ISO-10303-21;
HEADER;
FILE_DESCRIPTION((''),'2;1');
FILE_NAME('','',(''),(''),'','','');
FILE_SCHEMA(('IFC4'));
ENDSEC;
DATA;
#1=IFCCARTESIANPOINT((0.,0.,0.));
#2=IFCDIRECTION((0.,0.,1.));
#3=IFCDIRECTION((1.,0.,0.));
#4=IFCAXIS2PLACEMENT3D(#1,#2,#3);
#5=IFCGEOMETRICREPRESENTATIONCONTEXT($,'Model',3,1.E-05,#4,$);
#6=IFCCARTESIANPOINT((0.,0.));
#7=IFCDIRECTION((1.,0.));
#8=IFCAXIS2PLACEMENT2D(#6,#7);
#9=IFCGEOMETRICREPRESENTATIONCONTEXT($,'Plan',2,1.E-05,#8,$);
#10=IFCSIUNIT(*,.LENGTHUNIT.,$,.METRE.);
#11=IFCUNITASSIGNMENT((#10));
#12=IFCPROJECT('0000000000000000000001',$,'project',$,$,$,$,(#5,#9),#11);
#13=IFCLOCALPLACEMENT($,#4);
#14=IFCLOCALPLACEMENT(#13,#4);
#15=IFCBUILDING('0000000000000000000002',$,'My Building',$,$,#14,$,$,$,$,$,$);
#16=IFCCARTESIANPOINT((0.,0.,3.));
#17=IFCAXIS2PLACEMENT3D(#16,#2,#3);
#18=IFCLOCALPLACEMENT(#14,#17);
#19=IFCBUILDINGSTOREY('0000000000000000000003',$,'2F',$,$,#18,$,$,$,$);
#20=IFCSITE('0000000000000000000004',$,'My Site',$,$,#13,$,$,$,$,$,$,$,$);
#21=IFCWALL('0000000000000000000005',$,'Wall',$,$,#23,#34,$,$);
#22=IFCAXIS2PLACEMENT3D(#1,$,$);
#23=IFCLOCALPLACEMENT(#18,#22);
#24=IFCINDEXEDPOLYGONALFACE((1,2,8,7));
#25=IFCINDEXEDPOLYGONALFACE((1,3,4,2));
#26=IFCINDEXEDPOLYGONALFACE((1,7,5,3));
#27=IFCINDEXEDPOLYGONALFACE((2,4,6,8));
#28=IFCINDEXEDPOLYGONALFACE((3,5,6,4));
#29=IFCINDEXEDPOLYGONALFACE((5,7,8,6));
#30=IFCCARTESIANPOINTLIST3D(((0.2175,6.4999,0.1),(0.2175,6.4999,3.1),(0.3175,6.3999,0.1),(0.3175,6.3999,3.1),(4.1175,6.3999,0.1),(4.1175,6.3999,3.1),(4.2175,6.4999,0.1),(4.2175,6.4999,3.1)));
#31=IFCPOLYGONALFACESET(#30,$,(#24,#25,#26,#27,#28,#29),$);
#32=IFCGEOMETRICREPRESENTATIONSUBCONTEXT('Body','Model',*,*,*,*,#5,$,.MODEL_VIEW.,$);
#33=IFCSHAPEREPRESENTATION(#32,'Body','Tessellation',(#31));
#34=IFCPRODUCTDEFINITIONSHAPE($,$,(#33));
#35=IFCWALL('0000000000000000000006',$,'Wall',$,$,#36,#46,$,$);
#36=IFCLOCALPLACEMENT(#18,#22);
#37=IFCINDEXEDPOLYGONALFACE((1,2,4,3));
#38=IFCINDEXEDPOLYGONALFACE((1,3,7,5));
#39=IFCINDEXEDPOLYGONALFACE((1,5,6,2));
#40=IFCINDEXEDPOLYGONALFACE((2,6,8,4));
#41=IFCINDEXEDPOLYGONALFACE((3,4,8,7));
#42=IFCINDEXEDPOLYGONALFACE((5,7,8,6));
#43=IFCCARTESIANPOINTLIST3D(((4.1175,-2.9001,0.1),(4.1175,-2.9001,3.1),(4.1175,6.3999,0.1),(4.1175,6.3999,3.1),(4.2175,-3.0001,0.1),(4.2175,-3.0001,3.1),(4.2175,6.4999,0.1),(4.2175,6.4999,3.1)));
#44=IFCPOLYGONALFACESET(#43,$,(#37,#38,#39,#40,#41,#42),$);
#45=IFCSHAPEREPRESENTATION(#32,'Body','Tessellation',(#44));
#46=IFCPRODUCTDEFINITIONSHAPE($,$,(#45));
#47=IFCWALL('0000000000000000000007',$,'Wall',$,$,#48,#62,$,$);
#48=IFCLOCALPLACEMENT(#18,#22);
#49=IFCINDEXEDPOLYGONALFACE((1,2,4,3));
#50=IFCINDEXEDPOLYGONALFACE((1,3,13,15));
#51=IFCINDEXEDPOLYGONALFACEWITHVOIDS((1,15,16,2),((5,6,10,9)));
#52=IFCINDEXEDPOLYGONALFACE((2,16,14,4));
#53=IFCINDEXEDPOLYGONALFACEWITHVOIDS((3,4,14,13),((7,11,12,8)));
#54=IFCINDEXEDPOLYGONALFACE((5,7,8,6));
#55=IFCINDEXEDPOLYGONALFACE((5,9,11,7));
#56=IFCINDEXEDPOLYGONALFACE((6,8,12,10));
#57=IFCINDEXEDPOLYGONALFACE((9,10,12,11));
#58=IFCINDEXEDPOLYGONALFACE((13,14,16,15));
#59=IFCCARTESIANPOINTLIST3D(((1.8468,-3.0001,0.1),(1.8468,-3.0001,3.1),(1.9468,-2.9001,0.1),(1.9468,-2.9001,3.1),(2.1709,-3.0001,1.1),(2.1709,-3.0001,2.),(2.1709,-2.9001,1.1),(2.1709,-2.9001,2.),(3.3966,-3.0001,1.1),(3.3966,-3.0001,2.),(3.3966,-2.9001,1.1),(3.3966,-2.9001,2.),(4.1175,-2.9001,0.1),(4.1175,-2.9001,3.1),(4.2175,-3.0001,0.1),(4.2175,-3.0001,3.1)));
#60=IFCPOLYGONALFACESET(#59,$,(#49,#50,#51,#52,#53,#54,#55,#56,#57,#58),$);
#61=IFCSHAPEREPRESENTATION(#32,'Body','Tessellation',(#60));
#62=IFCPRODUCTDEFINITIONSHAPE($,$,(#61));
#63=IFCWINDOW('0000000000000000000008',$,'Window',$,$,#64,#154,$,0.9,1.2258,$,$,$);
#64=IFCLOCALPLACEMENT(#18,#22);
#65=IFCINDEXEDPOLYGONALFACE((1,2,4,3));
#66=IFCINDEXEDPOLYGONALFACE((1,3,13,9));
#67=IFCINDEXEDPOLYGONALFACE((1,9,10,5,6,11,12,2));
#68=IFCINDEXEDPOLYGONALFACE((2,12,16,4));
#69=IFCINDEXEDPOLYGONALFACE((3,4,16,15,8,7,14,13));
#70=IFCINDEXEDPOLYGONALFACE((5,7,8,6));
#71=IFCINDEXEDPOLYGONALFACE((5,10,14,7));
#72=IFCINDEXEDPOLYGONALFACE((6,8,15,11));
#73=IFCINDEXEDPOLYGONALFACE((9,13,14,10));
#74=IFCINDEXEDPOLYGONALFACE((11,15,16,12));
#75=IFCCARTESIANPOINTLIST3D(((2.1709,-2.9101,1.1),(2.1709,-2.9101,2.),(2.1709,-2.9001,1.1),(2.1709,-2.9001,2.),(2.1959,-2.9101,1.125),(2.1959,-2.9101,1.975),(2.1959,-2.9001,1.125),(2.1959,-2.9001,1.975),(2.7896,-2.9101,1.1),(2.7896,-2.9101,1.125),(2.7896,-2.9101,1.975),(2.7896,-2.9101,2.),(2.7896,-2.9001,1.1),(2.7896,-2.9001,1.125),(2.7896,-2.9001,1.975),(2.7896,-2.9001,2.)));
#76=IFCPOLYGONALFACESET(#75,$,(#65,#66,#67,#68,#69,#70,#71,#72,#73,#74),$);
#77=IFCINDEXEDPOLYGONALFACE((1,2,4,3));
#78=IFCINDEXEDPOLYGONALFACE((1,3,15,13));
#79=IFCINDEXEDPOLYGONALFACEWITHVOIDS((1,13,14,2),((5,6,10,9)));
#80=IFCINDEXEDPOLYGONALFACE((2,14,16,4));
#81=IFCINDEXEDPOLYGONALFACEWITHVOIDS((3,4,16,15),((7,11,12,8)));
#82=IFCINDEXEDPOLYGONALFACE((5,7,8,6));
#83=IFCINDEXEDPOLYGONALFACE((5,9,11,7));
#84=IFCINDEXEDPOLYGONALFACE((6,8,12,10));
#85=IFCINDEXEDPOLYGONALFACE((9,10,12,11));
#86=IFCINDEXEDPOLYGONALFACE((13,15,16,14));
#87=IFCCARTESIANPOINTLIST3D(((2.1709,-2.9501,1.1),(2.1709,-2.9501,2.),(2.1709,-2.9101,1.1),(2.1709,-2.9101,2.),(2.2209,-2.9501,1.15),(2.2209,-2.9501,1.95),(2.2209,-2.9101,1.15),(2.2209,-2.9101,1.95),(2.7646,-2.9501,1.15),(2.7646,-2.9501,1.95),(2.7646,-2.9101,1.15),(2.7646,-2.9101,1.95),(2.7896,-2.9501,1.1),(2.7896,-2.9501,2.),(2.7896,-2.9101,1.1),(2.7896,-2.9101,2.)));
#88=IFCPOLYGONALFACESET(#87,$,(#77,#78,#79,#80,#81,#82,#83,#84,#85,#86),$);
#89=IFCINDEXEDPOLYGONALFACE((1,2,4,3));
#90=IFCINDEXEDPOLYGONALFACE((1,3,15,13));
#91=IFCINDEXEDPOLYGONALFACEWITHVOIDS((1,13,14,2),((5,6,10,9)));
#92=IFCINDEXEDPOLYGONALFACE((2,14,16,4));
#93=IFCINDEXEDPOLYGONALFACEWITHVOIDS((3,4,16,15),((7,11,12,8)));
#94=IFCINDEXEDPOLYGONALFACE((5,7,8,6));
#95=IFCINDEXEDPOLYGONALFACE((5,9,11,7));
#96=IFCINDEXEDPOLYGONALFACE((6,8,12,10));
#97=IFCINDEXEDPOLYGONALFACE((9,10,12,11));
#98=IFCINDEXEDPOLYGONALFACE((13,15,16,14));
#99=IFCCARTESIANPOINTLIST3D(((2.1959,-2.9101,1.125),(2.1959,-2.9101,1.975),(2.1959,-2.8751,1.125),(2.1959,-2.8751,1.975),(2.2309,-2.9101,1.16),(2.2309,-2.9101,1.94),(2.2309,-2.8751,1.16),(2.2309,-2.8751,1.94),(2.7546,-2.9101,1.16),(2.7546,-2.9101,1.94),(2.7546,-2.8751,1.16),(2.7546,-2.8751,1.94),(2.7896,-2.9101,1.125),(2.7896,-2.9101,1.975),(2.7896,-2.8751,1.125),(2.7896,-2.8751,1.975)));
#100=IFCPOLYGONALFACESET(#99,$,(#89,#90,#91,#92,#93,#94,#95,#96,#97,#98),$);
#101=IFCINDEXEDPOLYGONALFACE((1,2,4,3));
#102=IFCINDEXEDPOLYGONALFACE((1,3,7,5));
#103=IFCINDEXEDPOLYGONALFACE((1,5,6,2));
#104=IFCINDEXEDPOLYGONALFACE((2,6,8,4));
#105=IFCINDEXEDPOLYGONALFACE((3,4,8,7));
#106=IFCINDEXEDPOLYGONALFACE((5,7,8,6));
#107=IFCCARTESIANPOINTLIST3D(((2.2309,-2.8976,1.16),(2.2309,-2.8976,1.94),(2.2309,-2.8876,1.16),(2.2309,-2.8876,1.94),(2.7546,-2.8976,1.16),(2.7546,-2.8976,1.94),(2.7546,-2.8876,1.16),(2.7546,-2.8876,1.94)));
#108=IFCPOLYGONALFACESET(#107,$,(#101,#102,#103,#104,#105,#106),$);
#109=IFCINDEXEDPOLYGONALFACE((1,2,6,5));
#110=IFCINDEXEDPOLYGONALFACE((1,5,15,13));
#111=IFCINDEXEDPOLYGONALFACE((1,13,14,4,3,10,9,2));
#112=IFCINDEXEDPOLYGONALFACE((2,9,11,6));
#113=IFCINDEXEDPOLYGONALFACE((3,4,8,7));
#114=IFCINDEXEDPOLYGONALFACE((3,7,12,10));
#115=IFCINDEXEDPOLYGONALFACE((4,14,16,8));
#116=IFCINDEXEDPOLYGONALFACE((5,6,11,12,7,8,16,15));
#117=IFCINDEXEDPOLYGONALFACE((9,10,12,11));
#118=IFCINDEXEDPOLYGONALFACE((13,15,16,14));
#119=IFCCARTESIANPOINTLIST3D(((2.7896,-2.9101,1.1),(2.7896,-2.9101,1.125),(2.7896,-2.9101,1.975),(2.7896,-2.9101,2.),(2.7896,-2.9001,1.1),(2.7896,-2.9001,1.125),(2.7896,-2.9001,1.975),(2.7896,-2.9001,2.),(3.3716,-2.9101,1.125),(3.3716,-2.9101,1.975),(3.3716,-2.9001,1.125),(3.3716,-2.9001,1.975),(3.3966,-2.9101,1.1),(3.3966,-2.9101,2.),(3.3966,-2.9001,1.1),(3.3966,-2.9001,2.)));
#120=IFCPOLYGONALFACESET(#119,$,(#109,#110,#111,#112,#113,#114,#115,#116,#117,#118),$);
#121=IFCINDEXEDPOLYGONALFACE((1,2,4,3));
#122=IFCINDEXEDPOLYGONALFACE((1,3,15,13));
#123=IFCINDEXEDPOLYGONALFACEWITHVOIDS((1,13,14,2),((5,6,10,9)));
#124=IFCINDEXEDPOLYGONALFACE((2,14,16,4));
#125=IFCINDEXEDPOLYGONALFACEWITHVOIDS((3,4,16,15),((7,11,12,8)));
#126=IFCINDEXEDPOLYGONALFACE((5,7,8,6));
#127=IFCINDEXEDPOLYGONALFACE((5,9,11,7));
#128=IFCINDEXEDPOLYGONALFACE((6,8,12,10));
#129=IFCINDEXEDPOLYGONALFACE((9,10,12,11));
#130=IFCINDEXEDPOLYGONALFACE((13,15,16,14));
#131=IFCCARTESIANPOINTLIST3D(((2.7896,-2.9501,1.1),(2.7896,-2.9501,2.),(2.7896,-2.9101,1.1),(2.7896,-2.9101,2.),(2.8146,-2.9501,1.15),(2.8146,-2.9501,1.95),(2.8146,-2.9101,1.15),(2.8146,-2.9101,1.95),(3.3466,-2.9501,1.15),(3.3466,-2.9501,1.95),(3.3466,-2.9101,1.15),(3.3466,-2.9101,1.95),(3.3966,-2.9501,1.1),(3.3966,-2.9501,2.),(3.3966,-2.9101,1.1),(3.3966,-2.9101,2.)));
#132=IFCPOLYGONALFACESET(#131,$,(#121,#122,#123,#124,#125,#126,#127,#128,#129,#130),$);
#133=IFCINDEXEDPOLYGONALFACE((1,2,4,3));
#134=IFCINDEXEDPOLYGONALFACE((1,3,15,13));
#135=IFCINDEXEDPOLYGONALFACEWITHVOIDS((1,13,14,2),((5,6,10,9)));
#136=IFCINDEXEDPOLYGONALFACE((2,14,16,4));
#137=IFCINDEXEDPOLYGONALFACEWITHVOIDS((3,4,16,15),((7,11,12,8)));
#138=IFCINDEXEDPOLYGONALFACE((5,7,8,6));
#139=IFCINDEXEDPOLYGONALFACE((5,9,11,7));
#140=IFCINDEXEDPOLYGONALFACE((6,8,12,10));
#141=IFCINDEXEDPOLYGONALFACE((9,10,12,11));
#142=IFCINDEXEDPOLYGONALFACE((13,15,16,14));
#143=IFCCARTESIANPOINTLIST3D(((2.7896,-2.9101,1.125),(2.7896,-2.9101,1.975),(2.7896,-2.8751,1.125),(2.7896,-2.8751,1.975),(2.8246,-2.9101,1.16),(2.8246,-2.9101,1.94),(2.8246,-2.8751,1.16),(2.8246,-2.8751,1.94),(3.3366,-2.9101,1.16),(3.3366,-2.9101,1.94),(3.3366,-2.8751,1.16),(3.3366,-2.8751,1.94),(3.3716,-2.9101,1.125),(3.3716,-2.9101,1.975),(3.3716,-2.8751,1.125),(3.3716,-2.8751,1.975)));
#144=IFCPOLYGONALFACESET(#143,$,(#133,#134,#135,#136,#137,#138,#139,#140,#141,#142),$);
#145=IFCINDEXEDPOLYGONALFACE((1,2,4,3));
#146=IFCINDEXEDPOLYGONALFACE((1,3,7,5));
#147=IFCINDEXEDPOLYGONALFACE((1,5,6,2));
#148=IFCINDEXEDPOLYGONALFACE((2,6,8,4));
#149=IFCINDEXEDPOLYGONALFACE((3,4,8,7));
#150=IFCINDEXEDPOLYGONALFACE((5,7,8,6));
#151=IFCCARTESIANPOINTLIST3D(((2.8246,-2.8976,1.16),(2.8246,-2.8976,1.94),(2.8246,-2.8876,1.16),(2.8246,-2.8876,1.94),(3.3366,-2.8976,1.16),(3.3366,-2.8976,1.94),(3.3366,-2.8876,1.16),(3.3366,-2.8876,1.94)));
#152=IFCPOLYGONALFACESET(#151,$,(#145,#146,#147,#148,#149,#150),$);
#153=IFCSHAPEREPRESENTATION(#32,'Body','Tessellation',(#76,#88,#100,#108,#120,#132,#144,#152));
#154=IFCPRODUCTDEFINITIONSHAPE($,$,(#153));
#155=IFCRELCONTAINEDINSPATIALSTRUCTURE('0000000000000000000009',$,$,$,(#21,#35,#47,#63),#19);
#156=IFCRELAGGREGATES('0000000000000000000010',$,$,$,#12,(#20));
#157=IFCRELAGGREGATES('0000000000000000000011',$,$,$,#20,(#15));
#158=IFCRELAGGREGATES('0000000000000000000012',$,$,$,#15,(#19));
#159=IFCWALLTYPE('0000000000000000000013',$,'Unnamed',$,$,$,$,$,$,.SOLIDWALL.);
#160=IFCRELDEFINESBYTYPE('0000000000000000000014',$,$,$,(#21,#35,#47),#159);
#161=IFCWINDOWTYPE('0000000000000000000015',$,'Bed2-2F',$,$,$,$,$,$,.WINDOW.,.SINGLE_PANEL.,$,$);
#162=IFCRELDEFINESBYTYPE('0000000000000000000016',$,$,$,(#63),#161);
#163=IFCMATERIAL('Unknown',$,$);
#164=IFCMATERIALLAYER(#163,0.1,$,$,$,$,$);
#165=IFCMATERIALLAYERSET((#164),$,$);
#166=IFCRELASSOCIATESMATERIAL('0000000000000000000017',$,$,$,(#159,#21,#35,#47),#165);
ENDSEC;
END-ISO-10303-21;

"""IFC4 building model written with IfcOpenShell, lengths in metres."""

from ifc_helpers import new_model, entity, si_unit, frame, origin_with_axes, origin_2d_with_axis, place, context, subcontext, project, spatial, line, indexed_curve, outline, extrude, shape, source, transform, mapped, material, layer, layer_set, layer_usage, type_object, type_shapes, element, fill, save


model = new_model("IFC4")

# Units and contexts
model_context = context("Model", 3, precision=1e-05, world=origin_with_axes())
plan_context = context("Plan", 2, precision=1e-05, world=origin_2d_with_axis())
body_context_1 = subcontext(model_context, "Body", "Model", "MODEL_VIEW")
body_context_2 = subcontext(plan_context, "Body", "Plan", "PLAN_VIEW")
ifc_project = project(units=[si_unit("LENGTHUNIT", "METRE")], contexts=[model_context, plan_context])

# Site, building, storey
site_placement = place(None, origin_with_axes())
site = spatial("IfcSite", under=ifc_project, at=site_placement, Name="My Site")
building_placement = place(site_placement, origin_with_axes())
building = spatial("IfcBuilding", under=site, at=building_placement, Name="My Building")
storey_placement = place(building_placement, frame((0.0, 0.0, 3.0), z_axis=(0.0, 0.0, 1.0), x_axis=(1.0, 0.0, 0.0)))
storey = spatial("IfcBuildingStorey", under=building, at=storey_placement, Name="2F")

# Walls
ifc_material = material(Name="Unknown")
ifc_layer = layer(ifc_material, 0.1)
ifc_layer_set = layer_set([ifc_layer])
ifc_layer_usage_1 = layer_usage(ifc_layer_set, "AXIS2", "POSITIVE", 0.0)
wall_type = type_object("IfcWallType", Name="Unnamed", PredefinedType="SOLIDWALL", material=ifc_layer_set)
wall_1_placement = place(storey_placement, frame((0.3175, 6.3999, 0.1), z_axis=(0.0, 0.0, 1.0), x_axis=(1.0, 0.0, 0.0)))
element("IfcWall", 1, at=wall_1_placement, inside=storey, type_object=wall_type, material=ifc_layer_usage_1, Name="Wall", context=body_context_1, shape_type="SweptSolid", body=[
    extrude(outline(indexed_curve([(0.0, 0.0), (-0.1, 0.1), (3.9, 0.1), (3.8, 0.0)], segments=[line(1, 2, 3, 4, 1)])), origin_with_axes(), (0.0, 0.0, 1.0), 3.0),
])
ifc_layer_usage_2 = layer_usage(ifc_layer_set, "AXIS2", "POSITIVE", 0.0)
wall_2_placement = place(storey_placement, frame((4.1175, 6.3999, 0.1), z_axis=(0.0, 0.0, 1.0), x_axis=(0.0, -1.0, 0.0)))
element("IfcWall", 2, at=wall_2_placement, inside=storey, type_object=wall_type, material=ifc_layer_usage_2, Name="Wall", context=body_context_1, shape_type="SweptSolid", body=[
    extrude(outline(indexed_curve([(0.0, 0.0), (-0.1, 0.1), (9.4, 0.1), (9.3, 0.0)], segments=[line(1, 2, 3, 4, 1)])), origin_with_axes(), (0.0, 0.0, 1.0), 3.0),
])

# Wall, opening, window
ifc_layer_usage_3 = layer_usage(ifc_layer_set, "AXIS2", "POSITIVE", 0.0)
wall_3_placement = place(storey_placement, frame((4.1175, -2.9001, 0.1), z_axis=(0.0, 0.0, 1.0), x_axis=(-1.0, 0.0, 0.0)))
wall_3 = element("IfcWall", 3, at=wall_3_placement, inside=storey, type_object=wall_type, material=ifc_layer_usage_3, Name="Wall", context=body_context_1, shape_type="SweptSolid", body=[
    extrude(outline(indexed_curve([(0.0, 0.0), (-0.1, 0.1), (2.2706, 0.1), (2.1706, 0.0)], segments=[line(1, 2, 3, 4, 1)])), origin_with_axes(), (0.0, 0.0, 1.0), 3.0),
])
shared_shape_1 = source(origin_with_axes(), body_context_1, "Body", "SweptSolid", [
    extrude(outline(indexed_curve([(0.0, 0.0), (1.2258, 0.0), (1.2258, 0.9), (0.0, 0.9)], segments=[line(1, 2, 3, 4, 1)])), frame((0.0, -0.6, 0.0), z_axis=(0.0, -1.0, 0.0), x_axis=(1.0, 0.0, 0.0)), (0.0, 0.0, -1.0), 1.2),
])
opening_1_placement = place(wall_3_placement, frame((1.9466, 0.1, 1.0), z_axis=(0.0, 0.0, 1.0), x_axis=(-1.0, 0.0, 0.0)))
opening_1 = element("IfcOpeningElement", 4, at=opening_1_placement, cuts=wall_3, PredefinedType="OPENING", context=body_context_1, shape_type="MappedRepresentation", body=[
    mapped(shared_shape_1, transform((0.0, 0.0, 0.0), x_axis=(1.0, 0.0, 0.0), y_axis=(0.0, 1.0, 0.0), z_axis=(0.0, 0.0, 1.0), scale=1.0)),
])
window_type_1 = type_object("IfcWindowType", Name="Bed2-2F", PartitioningType="SINGLE_PANEL", PredefinedType="WINDOW")
shared_shape_2 = source(origin_with_axes(), body_context_1, "Body", "SweptSolid", [
    extrude(outline(indexed_curve([(0.6187, 0.0), (0.0, 0.0), (0.0, 0.9), (0.6187, 0.9), (0.6187, 0.875), (0.025, 0.875), (0.025, 0.025), (0.6187, 0.025)], segments=[line(1, 2, 3, 4, 5, 6, 7, 8, 1)])), frame((0.0, 0.09, 0.0), z_axis=(0.0, -1.0, 0.0), x_axis=(1.0, 0.0, 0.0)), (0.0, 0.0, -1.0), 0.01),
    extrude(outline(indexed_curve([(0.0, 0.0), (0.6187, 0.0), (0.6187, 0.9), (0.0, 0.9)], segments=[line(1, 2, 3, 4, 1)]), holes=[indexed_curve([(0.05, 0.05), (0.5937, 0.05), (0.5937, 0.85), (0.05, 0.85)], segments=[line(1, 2, 3, 4, 1)])]), frame((0.0, 0.05, 0.0), z_axis=(0.0, -1.0, 0.0), x_axis=(1.0, 0.0, 0.0)), (0.0, 0.0, -1.0), 0.04),
    extrude(outline(indexed_curve([(0.0, 0.0), (0.5937, 0.0), (0.5937, 0.85), (0.0, 0.85)], segments=[line(1, 2, 3, 4, 1)]), holes=[indexed_curve([(0.035, 0.035), (0.5587, 0.035), (0.5587, 0.815), (0.035, 0.815)], segments=[line(1, 2, 3, 4, 1)])]), frame((0.025, 0.09, 0.025), z_axis=(0.0, -1.0, 0.0), x_axis=(1.0, 0.0, 0.0)), (0.0, 0.0, -1.0), 0.035),
    extrude(outline(indexed_curve([(0.035, 0.035), (0.5587, 0.035), (0.5587, 0.815), (0.035, 0.815)], segments=[line(1, 2, 3, 4, 1)])), frame((0.025, 0.1025, 0.025), z_axis=(0.0, -1.0, 0.0), x_axis=(1.0, 0.0, 0.0)), (0.0, 0.0, -1.0), 0.01),
    extrude(outline(indexed_curve([(0.0, 0.9), (0.6071, 0.9), (0.6071, 0.0), (0.0, 0.0), (0.0, 0.025), (0.5821, 0.025), (0.5821, 0.875), (0.0, 0.875)], segments=[line(1, 2, 3, 4, 5, 6, 7, 8, 1)])), frame((0.6187, 0.09, 0.0), z_axis=(0.0, -1.0, 0.0), x_axis=(1.0, 0.0, 0.0)), (0.0, 0.0, -1.0), 0.01),
    extrude(outline(indexed_curve([(0.0, 0.0), (0.6071, 0.0), (0.6071, 0.9), (0.0, 0.9)], segments=[line(1, 2, 3, 4, 1)]), holes=[indexed_curve([(0.025, 0.05), (0.5571, 0.05), (0.5571, 0.85), (0.025, 0.85)], segments=[line(1, 2, 3, 4, 1)])]), frame((0.6187, 0.05, 0.0), z_axis=(0.0, -1.0, 0.0), x_axis=(1.0, 0.0, 0.0)), (0.0, 0.0, -1.0), 0.04),
    extrude(outline(indexed_curve([(0.0, 0.0), (0.5821, 0.0), (0.5821, 0.85), (0.0, 0.85)], segments=[line(1, 2, 3, 4, 1)]), holes=[indexed_curve([(0.035, 0.035), (0.5471, 0.035), (0.5471, 0.815), (0.035, 0.815)], segments=[line(1, 2, 3, 4, 1)])]), frame((0.6187, 0.09, 0.025), z_axis=(0.0, -1.0, 0.0), x_axis=(1.0, 0.0, 0.0)), (0.0, 0.0, -1.0), 0.035),
    extrude(outline(indexed_curve([(0.035, 0.035), (0.5471, 0.035), (0.5471, 0.815), (0.035, 0.815)], segments=[line(1, 2, 3, 4, 1)])), frame((0.6187, 0.1025, 0.025), z_axis=(0.0, -1.0, 0.0), x_axis=(1.0, 0.0, 0.0)), (0.0, 0.0, -1.0), 0.01),
])
shared_shape_3 = source(origin_with_axes(), body_context_2, "Body", "Curve2D", [
    entity("IfcIndexedPolyCurve", entity("IfcCartesianPointList2D", [[0.05, 0.05], [0.5937, 0.05]])),
    entity("IfcIndexedPolyCurve", entity("IfcCartesianPointList2D", [[0.0, 0.1], [0.025, 0.1], [0.025, 0.09], [0.05, 0.09], [0.05, 0.05], [0.0, 0.05]]), [entity("IfcLineIndex", [1, 2, 3, 4, 5, 6, 1])]),
    entity("IfcIndexedPolyCurve", entity("IfcCartesianPointList2D", [[0.6187, 0.1], [0.6187, 0.1], [0.6187, 0.09], [0.5937, 0.09], [0.5937, 0.05], [0.6187, 0.05]])),
    entity("IfcIndexedPolyCurve", entity("IfcCartesianPointList2D", [[0.025, 0.09], [0.06, 0.09], [0.06, 0.125], [0.025, 0.125]]), [entity("IfcLineIndex", [1, 2, 3, 4, 1])]),
    entity("IfcIndexedPolyCurve", entity("IfcCartesianPointList2D", [[0.6187, 0.09], [0.5837, 0.09], [0.5837, 0.125], [0.6187, 0.125]]), [entity("IfcLineIndex", [1, 2, 3, 4, 1])]),
    entity("IfcIndexedPolyCurve", entity("IfcCartesianPointList2D", [[0.06, 0.09], [0.5837, 0.09]])),
    entity("IfcIndexedPolyCurve", entity("IfcCartesianPointList2D", [[0.06, 0.125], [0.5837, 0.125]])),
    entity("IfcIndexedPolyCurve", entity("IfcCartesianPointList2D", [[0.06, 0.1075], [0.5837, 0.1075]])),
    entity("IfcIndexedPolyCurve", entity("IfcCartesianPointList2D", [[0.6437, 0.05], [1.1758, 0.05]])),
    entity("IfcIndexedPolyCurve", entity("IfcCartesianPointList2D", [[0.6187, 0.1], [0.6187, 0.1], [0.6187, 0.09], [0.6437, 0.09], [0.6437, 0.05], [0.6187, 0.05]])),
    entity("IfcIndexedPolyCurve", entity("IfcCartesianPointList2D", [[1.2258, 0.1], [1.2008, 0.1], [1.2008, 0.09], [1.1758, 0.09], [1.1758, 0.05], [1.2258, 0.05]]), [entity("IfcLineIndex", [1, 2, 3, 4, 5, 6, 1])]),
    entity("IfcIndexedPolyCurve", entity("IfcCartesianPointList2D", [[0.6187, 0.09], [0.6537, 0.09], [0.6537, 0.125], [0.6187, 0.125]]), [entity("IfcLineIndex", [1, 2, 3, 4, 1])]),
    entity("IfcIndexedPolyCurve", entity("IfcCartesianPointList2D", [[1.2008, 0.09], [1.1658, 0.09], [1.1658, 0.125], [1.2008, 0.125]]), [entity("IfcLineIndex", [1, 2, 3, 4, 1])]),
    entity("IfcIndexedPolyCurve", entity("IfcCartesianPointList2D", [[0.6537, 0.09], [1.1658, 0.09]])),
    entity("IfcIndexedPolyCurve", entity("IfcCartesianPointList2D", [[0.6537, 0.125], [1.1658, 0.125]])),
    entity("IfcIndexedPolyCurve", entity("IfcCartesianPointList2D", [[0.6537, 0.1075], [1.1658, 0.1075]])),
])
type_shapes(window_type_1, [shared_shape_2, shared_shape_3])
window_1_placement = place(opening_1_placement, frame((0.0, 0.0, 0.0), z_axis=(0.0, 0.0, 1.0), x_axis=(1.0, 0.0, 0.0)))
window_1 = element("IfcWindow", 5, at=window_1_placement, inside=storey, type_object=window_type_1, Name="Window", OverallHeight=0.9, OverallWidth=1.2258, shapes=[
    shape(body_context_1, "Body", "MappedRepresentation", [mapped(shared_shape_2, transform((0.0, 0.0, 0.0), x_axis=(1.0, 0.0, 0.0), y_axis=(0.0, 1.0, 0.0), z_axis=(0.0, 0.0, 1.0), scale=1.0))]),
    shape(body_context_2, "Body", "MappedRepresentation", [mapped(shared_shape_3, transform((0.0, 0.0, 0.0), x_axis=(1.0, 0.0, 0.0), y_axis=(0.0, 1.0, 0.0), z_axis=(0.0, 0.0, 1.0), scale=1.0))]),
])
fill(opening_1, window_1)

save(model, "model.ifc")
